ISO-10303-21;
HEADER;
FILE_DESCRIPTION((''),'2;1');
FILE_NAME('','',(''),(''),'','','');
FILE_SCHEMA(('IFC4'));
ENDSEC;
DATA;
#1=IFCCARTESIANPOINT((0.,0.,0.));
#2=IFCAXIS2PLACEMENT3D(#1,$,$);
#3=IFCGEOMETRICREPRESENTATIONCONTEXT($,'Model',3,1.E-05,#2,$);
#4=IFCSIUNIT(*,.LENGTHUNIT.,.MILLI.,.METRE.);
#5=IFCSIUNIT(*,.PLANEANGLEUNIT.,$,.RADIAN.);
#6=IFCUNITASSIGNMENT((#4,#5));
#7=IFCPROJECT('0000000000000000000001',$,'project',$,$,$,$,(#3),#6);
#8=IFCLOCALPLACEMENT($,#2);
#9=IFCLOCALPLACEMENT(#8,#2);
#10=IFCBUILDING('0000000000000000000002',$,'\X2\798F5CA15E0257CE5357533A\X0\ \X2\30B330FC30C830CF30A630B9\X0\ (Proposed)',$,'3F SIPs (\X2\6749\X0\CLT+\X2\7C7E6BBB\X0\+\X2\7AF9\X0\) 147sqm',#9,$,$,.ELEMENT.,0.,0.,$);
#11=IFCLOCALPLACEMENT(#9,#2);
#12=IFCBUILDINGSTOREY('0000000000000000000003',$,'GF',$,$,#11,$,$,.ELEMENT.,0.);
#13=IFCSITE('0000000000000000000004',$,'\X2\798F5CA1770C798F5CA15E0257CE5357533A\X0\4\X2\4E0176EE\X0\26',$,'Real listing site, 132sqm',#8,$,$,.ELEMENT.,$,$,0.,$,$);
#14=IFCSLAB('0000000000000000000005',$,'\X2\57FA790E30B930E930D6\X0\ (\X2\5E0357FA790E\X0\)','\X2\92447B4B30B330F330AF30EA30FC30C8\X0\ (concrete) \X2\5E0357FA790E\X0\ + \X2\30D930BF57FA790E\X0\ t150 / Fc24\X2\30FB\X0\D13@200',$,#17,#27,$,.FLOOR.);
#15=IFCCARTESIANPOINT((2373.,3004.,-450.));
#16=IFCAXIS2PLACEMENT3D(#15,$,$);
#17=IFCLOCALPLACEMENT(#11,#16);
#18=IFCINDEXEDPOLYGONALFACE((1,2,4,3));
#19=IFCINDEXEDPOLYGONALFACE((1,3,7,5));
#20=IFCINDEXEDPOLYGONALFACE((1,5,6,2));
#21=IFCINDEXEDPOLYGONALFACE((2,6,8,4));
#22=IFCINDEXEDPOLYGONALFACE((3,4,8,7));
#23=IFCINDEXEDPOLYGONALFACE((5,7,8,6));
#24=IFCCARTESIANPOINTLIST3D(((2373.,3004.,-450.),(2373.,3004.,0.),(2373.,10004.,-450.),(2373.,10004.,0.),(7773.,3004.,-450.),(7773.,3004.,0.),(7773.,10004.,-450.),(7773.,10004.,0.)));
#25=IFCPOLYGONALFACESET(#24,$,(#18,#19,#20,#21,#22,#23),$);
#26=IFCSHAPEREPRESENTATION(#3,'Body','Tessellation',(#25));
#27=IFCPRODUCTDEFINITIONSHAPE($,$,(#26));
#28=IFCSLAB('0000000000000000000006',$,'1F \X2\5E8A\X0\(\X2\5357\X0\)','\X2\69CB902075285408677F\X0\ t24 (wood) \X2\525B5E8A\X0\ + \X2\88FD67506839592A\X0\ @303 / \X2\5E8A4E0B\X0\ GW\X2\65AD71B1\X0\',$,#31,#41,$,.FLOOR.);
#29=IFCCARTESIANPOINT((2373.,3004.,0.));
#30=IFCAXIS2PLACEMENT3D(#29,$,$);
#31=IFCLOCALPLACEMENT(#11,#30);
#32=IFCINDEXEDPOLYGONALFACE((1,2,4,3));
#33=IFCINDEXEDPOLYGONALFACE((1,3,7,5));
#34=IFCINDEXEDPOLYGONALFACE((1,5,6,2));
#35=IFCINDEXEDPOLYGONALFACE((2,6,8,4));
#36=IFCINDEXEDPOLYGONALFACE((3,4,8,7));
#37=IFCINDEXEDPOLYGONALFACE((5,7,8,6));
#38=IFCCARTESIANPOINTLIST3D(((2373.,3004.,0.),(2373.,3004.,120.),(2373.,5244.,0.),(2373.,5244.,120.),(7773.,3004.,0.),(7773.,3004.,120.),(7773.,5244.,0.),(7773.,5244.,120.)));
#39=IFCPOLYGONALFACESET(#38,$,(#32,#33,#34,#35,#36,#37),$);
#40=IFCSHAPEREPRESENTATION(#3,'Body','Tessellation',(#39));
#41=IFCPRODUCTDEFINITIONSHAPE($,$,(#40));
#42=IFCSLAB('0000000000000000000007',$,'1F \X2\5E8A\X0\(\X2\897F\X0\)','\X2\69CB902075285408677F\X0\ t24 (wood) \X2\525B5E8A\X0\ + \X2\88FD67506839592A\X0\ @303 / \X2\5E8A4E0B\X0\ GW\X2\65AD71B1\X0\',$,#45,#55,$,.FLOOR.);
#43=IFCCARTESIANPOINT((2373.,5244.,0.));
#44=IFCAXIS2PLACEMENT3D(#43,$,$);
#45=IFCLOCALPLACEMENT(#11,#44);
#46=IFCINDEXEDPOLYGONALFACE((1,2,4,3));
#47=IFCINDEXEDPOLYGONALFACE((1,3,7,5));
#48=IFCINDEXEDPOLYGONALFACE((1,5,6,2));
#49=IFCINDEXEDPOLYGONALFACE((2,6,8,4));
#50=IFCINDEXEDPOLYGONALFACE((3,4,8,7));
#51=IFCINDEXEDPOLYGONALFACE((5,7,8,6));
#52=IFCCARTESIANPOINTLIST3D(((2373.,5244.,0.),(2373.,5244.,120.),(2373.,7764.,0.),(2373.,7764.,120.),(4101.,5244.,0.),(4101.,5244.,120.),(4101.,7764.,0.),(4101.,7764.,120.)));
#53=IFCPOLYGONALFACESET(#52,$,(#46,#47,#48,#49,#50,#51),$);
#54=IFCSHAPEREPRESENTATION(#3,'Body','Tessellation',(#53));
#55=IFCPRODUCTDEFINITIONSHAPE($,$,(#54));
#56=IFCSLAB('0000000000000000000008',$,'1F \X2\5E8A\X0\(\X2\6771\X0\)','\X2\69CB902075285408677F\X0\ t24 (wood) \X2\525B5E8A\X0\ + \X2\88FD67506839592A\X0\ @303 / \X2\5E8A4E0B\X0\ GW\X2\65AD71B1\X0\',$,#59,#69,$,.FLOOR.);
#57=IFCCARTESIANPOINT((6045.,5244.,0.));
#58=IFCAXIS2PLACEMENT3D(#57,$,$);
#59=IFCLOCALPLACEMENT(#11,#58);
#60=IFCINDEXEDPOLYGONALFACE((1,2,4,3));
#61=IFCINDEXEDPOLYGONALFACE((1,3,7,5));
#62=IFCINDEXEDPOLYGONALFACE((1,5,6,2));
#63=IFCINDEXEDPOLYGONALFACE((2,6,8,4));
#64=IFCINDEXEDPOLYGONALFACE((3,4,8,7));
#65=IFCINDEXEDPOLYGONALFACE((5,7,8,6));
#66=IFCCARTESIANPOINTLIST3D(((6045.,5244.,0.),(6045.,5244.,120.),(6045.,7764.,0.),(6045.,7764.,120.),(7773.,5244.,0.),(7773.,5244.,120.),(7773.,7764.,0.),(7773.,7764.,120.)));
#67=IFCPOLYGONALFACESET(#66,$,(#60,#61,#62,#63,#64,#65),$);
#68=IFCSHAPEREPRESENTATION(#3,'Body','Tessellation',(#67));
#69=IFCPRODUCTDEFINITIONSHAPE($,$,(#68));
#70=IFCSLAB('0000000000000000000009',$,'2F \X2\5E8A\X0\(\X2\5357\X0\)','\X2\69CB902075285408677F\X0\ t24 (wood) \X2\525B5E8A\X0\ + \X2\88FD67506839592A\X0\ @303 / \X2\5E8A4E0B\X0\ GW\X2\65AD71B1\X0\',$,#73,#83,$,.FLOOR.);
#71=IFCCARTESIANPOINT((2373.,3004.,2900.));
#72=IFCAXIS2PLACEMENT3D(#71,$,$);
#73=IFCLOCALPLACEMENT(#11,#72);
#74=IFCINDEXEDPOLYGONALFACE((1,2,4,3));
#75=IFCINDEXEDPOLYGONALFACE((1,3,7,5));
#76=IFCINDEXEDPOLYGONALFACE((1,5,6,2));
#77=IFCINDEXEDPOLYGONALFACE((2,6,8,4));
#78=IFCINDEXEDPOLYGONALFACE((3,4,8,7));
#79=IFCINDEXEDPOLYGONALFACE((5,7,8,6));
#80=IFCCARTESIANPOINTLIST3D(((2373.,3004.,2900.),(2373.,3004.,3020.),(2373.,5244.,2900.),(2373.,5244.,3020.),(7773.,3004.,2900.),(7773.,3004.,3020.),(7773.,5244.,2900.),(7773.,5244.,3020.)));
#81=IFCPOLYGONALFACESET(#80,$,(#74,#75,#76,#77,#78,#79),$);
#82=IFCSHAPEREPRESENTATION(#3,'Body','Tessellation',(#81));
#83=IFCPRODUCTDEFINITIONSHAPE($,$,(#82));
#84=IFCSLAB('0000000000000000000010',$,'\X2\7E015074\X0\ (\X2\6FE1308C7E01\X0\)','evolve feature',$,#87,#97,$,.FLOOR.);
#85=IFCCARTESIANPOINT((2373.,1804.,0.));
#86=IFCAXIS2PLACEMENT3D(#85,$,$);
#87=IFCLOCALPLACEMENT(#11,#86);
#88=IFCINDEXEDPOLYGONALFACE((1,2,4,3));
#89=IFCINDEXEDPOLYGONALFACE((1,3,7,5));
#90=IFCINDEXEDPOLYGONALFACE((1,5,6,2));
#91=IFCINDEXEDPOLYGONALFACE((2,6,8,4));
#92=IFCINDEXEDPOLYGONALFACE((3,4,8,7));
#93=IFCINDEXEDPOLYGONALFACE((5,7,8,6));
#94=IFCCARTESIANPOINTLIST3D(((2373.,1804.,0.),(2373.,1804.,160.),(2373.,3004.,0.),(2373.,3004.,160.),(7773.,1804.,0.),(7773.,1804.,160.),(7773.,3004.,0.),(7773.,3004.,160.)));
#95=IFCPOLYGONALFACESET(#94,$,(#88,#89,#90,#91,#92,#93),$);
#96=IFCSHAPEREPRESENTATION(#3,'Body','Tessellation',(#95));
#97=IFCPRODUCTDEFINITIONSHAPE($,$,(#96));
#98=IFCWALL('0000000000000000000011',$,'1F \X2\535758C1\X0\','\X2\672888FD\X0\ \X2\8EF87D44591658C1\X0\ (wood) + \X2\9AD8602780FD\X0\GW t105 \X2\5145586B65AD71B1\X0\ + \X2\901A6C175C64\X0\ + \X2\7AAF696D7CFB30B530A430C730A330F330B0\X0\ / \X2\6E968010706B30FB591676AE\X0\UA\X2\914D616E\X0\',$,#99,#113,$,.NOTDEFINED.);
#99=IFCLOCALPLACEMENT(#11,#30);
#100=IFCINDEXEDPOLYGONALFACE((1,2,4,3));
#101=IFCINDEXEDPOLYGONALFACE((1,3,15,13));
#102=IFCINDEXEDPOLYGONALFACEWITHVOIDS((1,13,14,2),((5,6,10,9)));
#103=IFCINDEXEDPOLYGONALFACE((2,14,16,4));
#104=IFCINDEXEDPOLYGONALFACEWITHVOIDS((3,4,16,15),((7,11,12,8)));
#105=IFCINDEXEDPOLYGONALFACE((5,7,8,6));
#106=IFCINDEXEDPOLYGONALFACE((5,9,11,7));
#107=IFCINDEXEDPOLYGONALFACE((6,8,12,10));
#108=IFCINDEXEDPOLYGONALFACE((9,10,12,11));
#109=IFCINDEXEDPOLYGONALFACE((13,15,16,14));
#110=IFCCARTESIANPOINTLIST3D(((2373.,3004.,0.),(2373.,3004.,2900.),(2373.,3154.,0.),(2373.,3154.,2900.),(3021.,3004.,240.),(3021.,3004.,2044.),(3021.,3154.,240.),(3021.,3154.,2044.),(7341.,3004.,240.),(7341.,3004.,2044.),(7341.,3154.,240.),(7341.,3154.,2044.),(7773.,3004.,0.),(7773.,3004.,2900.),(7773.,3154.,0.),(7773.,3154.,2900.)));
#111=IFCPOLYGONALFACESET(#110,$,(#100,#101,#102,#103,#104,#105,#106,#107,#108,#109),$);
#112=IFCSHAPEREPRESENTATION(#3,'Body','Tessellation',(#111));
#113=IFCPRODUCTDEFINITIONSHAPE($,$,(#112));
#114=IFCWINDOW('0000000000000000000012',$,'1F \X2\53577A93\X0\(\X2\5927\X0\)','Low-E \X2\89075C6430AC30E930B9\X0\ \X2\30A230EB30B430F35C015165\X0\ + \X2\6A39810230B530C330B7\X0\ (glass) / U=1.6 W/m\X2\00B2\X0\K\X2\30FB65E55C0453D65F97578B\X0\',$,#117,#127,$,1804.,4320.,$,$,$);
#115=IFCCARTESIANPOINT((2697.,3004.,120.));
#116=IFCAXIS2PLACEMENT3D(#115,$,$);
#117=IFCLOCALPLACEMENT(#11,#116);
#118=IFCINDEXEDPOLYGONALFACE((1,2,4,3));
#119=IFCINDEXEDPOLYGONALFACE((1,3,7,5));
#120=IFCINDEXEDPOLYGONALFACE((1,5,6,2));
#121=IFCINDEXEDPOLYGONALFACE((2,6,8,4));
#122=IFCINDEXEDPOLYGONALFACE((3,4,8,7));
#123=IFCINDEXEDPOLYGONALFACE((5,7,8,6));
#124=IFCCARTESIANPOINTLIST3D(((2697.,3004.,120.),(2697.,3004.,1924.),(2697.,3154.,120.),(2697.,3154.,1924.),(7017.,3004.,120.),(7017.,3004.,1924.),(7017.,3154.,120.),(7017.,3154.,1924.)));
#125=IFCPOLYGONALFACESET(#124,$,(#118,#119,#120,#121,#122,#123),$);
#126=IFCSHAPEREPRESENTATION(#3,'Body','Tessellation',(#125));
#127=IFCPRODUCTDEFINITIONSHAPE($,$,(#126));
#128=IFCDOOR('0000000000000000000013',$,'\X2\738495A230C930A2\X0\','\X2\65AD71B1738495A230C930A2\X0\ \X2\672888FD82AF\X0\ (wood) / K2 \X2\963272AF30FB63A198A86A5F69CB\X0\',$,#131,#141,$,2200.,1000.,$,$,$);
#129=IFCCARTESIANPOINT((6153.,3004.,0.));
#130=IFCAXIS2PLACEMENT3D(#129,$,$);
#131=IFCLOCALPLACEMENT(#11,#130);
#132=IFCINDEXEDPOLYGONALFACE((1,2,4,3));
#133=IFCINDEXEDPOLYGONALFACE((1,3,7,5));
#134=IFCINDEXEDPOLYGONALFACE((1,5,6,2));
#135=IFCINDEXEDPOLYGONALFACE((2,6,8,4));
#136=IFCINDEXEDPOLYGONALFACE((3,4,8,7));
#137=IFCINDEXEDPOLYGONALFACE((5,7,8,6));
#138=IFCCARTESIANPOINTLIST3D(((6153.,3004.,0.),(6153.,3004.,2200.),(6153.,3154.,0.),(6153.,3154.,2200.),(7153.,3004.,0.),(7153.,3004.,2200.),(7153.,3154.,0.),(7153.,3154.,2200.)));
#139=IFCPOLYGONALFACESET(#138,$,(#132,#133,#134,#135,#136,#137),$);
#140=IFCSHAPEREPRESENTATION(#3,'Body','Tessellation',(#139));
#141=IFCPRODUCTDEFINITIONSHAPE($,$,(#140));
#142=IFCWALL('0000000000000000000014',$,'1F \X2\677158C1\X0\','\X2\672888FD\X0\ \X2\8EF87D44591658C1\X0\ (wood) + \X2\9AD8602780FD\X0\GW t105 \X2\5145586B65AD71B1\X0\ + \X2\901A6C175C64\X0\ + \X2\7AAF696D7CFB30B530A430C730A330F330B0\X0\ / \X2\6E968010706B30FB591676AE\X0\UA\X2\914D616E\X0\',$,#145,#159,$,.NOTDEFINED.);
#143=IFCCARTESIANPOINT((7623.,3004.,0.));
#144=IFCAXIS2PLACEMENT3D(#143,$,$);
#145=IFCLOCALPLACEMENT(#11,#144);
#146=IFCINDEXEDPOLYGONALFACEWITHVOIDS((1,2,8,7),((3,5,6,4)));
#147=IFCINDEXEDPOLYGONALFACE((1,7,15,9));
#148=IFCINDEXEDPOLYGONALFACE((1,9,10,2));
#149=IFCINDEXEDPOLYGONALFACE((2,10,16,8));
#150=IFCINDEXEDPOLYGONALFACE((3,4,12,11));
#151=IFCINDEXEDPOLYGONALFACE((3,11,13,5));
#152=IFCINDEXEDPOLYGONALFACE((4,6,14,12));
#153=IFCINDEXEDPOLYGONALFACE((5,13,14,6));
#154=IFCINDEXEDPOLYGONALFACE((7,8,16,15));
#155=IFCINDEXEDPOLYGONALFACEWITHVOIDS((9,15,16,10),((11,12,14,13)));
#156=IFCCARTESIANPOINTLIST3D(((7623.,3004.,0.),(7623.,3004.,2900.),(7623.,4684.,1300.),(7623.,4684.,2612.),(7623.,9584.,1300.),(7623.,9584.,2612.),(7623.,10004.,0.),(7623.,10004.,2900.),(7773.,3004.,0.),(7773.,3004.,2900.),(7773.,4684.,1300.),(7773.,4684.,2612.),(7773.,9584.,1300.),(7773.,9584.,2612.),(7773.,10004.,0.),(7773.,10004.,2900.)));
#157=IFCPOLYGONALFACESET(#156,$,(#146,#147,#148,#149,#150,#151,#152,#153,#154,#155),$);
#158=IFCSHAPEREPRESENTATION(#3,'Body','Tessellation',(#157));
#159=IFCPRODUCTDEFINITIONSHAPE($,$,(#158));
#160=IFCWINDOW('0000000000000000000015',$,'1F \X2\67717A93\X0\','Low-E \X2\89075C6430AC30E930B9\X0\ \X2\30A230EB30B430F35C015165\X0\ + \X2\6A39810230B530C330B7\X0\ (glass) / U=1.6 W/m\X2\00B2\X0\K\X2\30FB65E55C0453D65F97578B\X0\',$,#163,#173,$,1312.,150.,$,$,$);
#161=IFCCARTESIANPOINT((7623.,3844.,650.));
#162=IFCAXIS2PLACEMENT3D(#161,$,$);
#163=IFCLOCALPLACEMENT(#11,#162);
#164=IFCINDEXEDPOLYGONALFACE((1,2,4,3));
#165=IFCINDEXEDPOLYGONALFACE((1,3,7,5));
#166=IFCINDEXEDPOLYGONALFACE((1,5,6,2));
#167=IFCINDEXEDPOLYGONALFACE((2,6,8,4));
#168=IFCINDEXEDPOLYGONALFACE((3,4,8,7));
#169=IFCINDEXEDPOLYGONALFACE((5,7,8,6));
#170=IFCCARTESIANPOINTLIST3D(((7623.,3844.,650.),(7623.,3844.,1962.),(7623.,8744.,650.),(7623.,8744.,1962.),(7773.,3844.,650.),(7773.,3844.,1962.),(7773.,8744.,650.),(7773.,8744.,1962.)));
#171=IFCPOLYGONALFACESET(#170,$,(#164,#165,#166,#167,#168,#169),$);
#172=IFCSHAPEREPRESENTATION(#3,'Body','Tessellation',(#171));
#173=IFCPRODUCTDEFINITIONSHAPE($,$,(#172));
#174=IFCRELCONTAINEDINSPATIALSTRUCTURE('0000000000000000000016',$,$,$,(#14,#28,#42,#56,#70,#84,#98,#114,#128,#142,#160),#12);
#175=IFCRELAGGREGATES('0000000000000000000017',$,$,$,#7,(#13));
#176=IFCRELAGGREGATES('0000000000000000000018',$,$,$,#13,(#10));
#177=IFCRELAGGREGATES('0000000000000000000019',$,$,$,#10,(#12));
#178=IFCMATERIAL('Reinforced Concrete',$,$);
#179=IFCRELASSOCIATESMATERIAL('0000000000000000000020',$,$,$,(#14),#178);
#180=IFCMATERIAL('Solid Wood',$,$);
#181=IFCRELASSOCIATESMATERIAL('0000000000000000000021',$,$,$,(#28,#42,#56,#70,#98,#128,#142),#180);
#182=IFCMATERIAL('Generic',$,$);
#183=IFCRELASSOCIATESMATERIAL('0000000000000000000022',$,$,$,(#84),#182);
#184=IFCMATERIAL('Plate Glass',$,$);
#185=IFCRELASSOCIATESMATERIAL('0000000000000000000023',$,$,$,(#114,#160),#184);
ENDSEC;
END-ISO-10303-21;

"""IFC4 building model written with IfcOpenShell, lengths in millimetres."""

from ifc_helpers import new_model, si_unit, frame, frame_2d, origin, place, context, project, spatial, rectangle, extrude, material, element, fill, save


model = new_model("IFC4")

# Units and contexts
model_context = context("Model", 3, precision=1e-05, world=origin())
ifc_project = project(units=[si_unit("LENGTHUNIT", "METRE", prefix="MILLI"), si_unit("PLANEANGLEUNIT", "RADIAN")], contexts=[model_context])

# Site, building, storey
site_placement = place(None, origin())
site = spatial("IfcSite", under=ifc_project, at=site_placement, Name="福岡県福岡市城南区4丁目26", ObjectType="Real listing site, 132sqm", CompositionType="ELEMENT", RefElevation=0.0)
building_placement = place(site_placement, origin())
building = spatial("IfcBuilding", under=site, at=building_placement, Name="福岡市城南区 コートハウス (Proposed)", ObjectType="3F SIPs (杉CLT+籾殻+竹) 147sqm", CompositionType="ELEMENT", ElevationOfRefHeight=0.0, ElevationOfTerrain=0.0)
storey_placement = place(building_placement, origin())
storey = spatial("IfcBuildingStorey", under=building, at=storey_placement, Name="GF", CompositionType="ELEMENT", Elevation=0.0)

# Slabs
ifc_material_1 = material(Name="Reinforced Concrete")
slab_1_placement = place(storey_placement, frame((2373.0, 3004.0, -450.0)))
element("IfcSlab", 1, at=slab_1_placement, inside=storey, material=ifc_material_1, Name="基礎スラブ (布基礎)", Description="鉄筋コンクリート (concrete) 布基礎 + ベタ基礎 t150 / Fc24・D13@200", PredefinedType="FLOOR", context=model_context, shape_type="SweptSolid", body=[
    extrude(rectangle(XDim=5400.0, YDim=7000.0, at=frame_2d((2700.0, 3500.0))), frame((2373.0, 3004.0, -450.0)), (0.0, 0.0, 1.0), 450.0),
])
ifc_material_2 = material(Name="Solid Wood")
slab_2_placement = place(storey_placement, frame((2373.0, 3004.0, 0.0)))
element("IfcSlab", 2, at=slab_2_placement, inside=storey, material=ifc_material_2, Name="1F 床(南)", Description="構造用合板 t24 (wood) 剛床 + 製材根太 @303 / 床下 GW断熱", PredefinedType="FLOOR", context=model_context, shape_type="SweptSolid", body=[
    extrude(rectangle(XDim=5400.0, YDim=2240.0, at=frame_2d((2700.0, 1120.0))), frame((2373.0, 3004.0, 0.0)), (0.0, 0.0, 1.0), 120.0),
])
slab_3_placement = place(storey_placement, frame((2373.0, 5244.0, 0.0)))
element("IfcSlab", 3, at=slab_3_placement, inside=storey, material=ifc_material_2, Name="1F 床(西)", Description="構造用合板 t24 (wood) 剛床 + 製材根太 @303 / 床下 GW断熱", PredefinedType="FLOOR", context=model_context, shape_type="SweptSolid", body=[
    extrude(rectangle(XDim=1728.0, YDim=2520.0, at=frame_2d((864.0, 1260.0))), frame((2373.0, 5244.0, 0.0)), (0.0, 0.0, 1.0), 120.0),
])
slab_4_placement = place(storey_placement, frame((6045.0, 5244.0, 0.0)))
element("IfcSlab", 4, at=slab_4_placement, inside=storey, material=ifc_material_2, Name="1F 床(東)", Description="構造用合板 t24 (wood) 剛床 + 製材根太 @303 / 床下 GW断熱", PredefinedType="FLOOR", context=model_context, shape_type="SweptSolid", body=[
    extrude(rectangle(XDim=1728.0, YDim=2520.0, at=frame_2d((864.0, 1260.0))), frame((6045.0, 5244.0, 0.0)), (0.0, 0.0, 1.0), 120.0),
])
slab_5_placement = place(storey_placement, frame((2373.0, 3004.0, 2900.0)))
element("IfcSlab", 5, at=slab_5_placement, inside=storey, material=ifc_material_2, Name="2F 床(南)", Description="構造用合板 t24 (wood) 剛床 + 製材根太 @303 / 床下 GW断熱", PredefinedType="FLOOR", context=model_context, shape_type="SweptSolid", body=[
    extrude(rectangle(XDim=5400.0, YDim=2240.0, at=frame_2d((2700.0, 1120.0))), frame((2373.0, 3004.0, 2900.0)), (0.0, 0.0, 1.0), 120.0),
])
ifc_material_3 = material(Name="Generic")
slab_6_placement = place(storey_placement, frame((2373.0, 1804.0, 0.0)))
element("IfcSlab", 6, at=slab_6_placement, inside=storey, material=ifc_material_3, Name="縁側 (濡れ縁)", Description="evolve feature", PredefinedType="FLOOR", context=model_context, shape_type="SweptSolid", body=[
    extrude(rectangle(XDim=5400.0, YDim=1200.0, at=frame_2d((2700.0, 600.0))), frame((2373.0, 1804.0, 0.0)), (0.0, 0.0, 1.0), 160.0),
])

# Wall, openings, window, door
wall_1_placement = place(storey_placement, frame((2373.0, 3004.0, 0.0)))
wall_1 = element("IfcWall", 7, at=wall_1_placement, inside=storey, material=ifc_material_2, Name="1F 南壁", Description="木製 軸組外壁 (wood) + 高性能GW t105 充填断熱 + 通気層 + 窯業系サイディング / 準耐火・外皮UA配慮", PredefinedType="NOTDEFINED", context=model_context, shape_type="SweptSolid", body=[
    extrude(rectangle(XDim=5400.0, YDim=150.0, at=frame_2d((2700.0, 75.0))), frame((2373.0, 3004.0, 0.0)), (0.0, 0.0, 1.0), 2900.0),
])
opening_1_placement = place(storey_placement, frame((2697.0, 3004.0, 120.0)))
opening_1 = element("IfcOpeningElement", 8, at=opening_1_placement, cuts=wall_1, PredefinedType="NOTDEFINED", context=model_context, shape_type="SweptSolid", body=[
    extrude(rectangle(XDim=4320.0, YDim=150.0, at=frame_2d((2160.0, 75.0))), frame((2697.0, 3004.0, 120.0)), (0.0, 0.0, 1.0), 1804.0),
])
opening_2_placement = place(storey_placement, frame((6153.0, 3004.0, 0.0)))
opening_2 = element("IfcOpeningElement", 9, at=opening_2_placement, cuts=wall_1, PredefinedType="NOTDEFINED", context=model_context, shape_type="SweptSolid", body=[
    extrude(rectangle(XDim=1000.0, YDim=150.0, at=frame_2d((500.0, 75.0))), frame((6153.0, 3004.0, 0.0)), (0.0, 0.0, 1.0), 2200.0),
])
ifc_material_4 = material(Name="Plate Glass")
window_1_placement = place(storey_placement, frame((2697.0, 3004.0, 120.0)))
window_1 = element("IfcWindow", 10, at=window_1_placement, inside=storey, material=ifc_material_4, Name="1F 南窓(大)", Description="Low-E 複層ガラス アルゴン封入 + 樹脂サッシ (glass) / U=1.6 W/m²K・日射取得型", OverallHeight=1804.0, OverallWidth=4320.0, context=model_context, shape_type="SweptSolid", body=[
    extrude(rectangle(XDim=4320.0, YDim=150.0, at=frame_2d((2160.0, 75.0))), frame((2697.0, 3004.0, 120.0)), (0.0, 0.0, 1.0), 1804.0),
])
fill(opening_1, window_1)
door_placement = place(storey_placement, frame((6153.0, 3004.0, 0.0)))
door = element("IfcDoor", 11, at=door_placement, inside=storey, material=ifc_material_2, Name="玄関ドア", Description="断熱玄関ドア 木製芯 (wood) / K2 防犯・採風機構", OverallHeight=2200.0, OverallWidth=1000.0, context=model_context, shape_type="SweptSolid", body=[
    extrude(rectangle(XDim=1000.0, YDim=150.0, at=frame_2d((500.0, 75.0))), frame((6153.0, 3004.0, 0.0)), (0.0, 0.0, 1.0), 2200.0),
])
fill(opening_2, door)

# Wall, opening, window
wall_2_placement = place(storey_placement, frame((7623.0, 3004.0, 0.0)))
wall_2 = element("IfcWall", 12, at=wall_2_placement, inside=storey, material=ifc_material_2, Name="1F 東壁", Description="木製 軸組外壁 (wood) + 高性能GW t105 充填断熱 + 通気層 + 窯業系サイディング / 準耐火・外皮UA配慮", PredefinedType="NOTDEFINED", context=model_context, shape_type="SweptSolid", body=[
    extrude(rectangle(XDim=150.0, YDim=7000.0, at=frame_2d((75.0, 3500.0))), frame((7623.0, 3004.0, 0.0)), (0.0, 0.0, 1.0), 2900.0),
])
opening_3_placement = place(storey_placement, frame((7623.0, 3844.0, 650.0)))
opening_3 = element("IfcOpeningElement", 13, at=opening_3_placement, cuts=wall_2, PredefinedType="NOTDEFINED", context=model_context, shape_type="SweptSolid", body=[
    extrude(rectangle(XDim=150.0, YDim=4900.0, at=frame_2d((75.0, 2450.0))), frame((7623.0, 3844.0, 650.0)), (0.0, 0.0, 1.0), 1312.0),
])
window_2_placement = place(storey_placement, frame((7623.0, 3844.0, 650.0)))
window_2 = element("IfcWindow", 14, at=window_2_placement, inside=storey, material=ifc_material_4, Name="1F 東窓", Description="Low-E 複層ガラス アルゴン封入 + 樹脂サッシ (glass) / U=1.6 W/m²K・日射取得型", OverallHeight=1312.0, OverallWidth=150.0, context=model_context, shape_type="SweptSolid", body=[
    extrude(rectangle(XDim=150.0, YDim=4900.0, at=frame_2d((75.0, 2450.0))), frame((7623.0, 3844.0, 650.0)), (0.0, 0.0, 1.0), 1312.0),
])
fill(opening_3, window_2)

save(model, "model.ifc")
